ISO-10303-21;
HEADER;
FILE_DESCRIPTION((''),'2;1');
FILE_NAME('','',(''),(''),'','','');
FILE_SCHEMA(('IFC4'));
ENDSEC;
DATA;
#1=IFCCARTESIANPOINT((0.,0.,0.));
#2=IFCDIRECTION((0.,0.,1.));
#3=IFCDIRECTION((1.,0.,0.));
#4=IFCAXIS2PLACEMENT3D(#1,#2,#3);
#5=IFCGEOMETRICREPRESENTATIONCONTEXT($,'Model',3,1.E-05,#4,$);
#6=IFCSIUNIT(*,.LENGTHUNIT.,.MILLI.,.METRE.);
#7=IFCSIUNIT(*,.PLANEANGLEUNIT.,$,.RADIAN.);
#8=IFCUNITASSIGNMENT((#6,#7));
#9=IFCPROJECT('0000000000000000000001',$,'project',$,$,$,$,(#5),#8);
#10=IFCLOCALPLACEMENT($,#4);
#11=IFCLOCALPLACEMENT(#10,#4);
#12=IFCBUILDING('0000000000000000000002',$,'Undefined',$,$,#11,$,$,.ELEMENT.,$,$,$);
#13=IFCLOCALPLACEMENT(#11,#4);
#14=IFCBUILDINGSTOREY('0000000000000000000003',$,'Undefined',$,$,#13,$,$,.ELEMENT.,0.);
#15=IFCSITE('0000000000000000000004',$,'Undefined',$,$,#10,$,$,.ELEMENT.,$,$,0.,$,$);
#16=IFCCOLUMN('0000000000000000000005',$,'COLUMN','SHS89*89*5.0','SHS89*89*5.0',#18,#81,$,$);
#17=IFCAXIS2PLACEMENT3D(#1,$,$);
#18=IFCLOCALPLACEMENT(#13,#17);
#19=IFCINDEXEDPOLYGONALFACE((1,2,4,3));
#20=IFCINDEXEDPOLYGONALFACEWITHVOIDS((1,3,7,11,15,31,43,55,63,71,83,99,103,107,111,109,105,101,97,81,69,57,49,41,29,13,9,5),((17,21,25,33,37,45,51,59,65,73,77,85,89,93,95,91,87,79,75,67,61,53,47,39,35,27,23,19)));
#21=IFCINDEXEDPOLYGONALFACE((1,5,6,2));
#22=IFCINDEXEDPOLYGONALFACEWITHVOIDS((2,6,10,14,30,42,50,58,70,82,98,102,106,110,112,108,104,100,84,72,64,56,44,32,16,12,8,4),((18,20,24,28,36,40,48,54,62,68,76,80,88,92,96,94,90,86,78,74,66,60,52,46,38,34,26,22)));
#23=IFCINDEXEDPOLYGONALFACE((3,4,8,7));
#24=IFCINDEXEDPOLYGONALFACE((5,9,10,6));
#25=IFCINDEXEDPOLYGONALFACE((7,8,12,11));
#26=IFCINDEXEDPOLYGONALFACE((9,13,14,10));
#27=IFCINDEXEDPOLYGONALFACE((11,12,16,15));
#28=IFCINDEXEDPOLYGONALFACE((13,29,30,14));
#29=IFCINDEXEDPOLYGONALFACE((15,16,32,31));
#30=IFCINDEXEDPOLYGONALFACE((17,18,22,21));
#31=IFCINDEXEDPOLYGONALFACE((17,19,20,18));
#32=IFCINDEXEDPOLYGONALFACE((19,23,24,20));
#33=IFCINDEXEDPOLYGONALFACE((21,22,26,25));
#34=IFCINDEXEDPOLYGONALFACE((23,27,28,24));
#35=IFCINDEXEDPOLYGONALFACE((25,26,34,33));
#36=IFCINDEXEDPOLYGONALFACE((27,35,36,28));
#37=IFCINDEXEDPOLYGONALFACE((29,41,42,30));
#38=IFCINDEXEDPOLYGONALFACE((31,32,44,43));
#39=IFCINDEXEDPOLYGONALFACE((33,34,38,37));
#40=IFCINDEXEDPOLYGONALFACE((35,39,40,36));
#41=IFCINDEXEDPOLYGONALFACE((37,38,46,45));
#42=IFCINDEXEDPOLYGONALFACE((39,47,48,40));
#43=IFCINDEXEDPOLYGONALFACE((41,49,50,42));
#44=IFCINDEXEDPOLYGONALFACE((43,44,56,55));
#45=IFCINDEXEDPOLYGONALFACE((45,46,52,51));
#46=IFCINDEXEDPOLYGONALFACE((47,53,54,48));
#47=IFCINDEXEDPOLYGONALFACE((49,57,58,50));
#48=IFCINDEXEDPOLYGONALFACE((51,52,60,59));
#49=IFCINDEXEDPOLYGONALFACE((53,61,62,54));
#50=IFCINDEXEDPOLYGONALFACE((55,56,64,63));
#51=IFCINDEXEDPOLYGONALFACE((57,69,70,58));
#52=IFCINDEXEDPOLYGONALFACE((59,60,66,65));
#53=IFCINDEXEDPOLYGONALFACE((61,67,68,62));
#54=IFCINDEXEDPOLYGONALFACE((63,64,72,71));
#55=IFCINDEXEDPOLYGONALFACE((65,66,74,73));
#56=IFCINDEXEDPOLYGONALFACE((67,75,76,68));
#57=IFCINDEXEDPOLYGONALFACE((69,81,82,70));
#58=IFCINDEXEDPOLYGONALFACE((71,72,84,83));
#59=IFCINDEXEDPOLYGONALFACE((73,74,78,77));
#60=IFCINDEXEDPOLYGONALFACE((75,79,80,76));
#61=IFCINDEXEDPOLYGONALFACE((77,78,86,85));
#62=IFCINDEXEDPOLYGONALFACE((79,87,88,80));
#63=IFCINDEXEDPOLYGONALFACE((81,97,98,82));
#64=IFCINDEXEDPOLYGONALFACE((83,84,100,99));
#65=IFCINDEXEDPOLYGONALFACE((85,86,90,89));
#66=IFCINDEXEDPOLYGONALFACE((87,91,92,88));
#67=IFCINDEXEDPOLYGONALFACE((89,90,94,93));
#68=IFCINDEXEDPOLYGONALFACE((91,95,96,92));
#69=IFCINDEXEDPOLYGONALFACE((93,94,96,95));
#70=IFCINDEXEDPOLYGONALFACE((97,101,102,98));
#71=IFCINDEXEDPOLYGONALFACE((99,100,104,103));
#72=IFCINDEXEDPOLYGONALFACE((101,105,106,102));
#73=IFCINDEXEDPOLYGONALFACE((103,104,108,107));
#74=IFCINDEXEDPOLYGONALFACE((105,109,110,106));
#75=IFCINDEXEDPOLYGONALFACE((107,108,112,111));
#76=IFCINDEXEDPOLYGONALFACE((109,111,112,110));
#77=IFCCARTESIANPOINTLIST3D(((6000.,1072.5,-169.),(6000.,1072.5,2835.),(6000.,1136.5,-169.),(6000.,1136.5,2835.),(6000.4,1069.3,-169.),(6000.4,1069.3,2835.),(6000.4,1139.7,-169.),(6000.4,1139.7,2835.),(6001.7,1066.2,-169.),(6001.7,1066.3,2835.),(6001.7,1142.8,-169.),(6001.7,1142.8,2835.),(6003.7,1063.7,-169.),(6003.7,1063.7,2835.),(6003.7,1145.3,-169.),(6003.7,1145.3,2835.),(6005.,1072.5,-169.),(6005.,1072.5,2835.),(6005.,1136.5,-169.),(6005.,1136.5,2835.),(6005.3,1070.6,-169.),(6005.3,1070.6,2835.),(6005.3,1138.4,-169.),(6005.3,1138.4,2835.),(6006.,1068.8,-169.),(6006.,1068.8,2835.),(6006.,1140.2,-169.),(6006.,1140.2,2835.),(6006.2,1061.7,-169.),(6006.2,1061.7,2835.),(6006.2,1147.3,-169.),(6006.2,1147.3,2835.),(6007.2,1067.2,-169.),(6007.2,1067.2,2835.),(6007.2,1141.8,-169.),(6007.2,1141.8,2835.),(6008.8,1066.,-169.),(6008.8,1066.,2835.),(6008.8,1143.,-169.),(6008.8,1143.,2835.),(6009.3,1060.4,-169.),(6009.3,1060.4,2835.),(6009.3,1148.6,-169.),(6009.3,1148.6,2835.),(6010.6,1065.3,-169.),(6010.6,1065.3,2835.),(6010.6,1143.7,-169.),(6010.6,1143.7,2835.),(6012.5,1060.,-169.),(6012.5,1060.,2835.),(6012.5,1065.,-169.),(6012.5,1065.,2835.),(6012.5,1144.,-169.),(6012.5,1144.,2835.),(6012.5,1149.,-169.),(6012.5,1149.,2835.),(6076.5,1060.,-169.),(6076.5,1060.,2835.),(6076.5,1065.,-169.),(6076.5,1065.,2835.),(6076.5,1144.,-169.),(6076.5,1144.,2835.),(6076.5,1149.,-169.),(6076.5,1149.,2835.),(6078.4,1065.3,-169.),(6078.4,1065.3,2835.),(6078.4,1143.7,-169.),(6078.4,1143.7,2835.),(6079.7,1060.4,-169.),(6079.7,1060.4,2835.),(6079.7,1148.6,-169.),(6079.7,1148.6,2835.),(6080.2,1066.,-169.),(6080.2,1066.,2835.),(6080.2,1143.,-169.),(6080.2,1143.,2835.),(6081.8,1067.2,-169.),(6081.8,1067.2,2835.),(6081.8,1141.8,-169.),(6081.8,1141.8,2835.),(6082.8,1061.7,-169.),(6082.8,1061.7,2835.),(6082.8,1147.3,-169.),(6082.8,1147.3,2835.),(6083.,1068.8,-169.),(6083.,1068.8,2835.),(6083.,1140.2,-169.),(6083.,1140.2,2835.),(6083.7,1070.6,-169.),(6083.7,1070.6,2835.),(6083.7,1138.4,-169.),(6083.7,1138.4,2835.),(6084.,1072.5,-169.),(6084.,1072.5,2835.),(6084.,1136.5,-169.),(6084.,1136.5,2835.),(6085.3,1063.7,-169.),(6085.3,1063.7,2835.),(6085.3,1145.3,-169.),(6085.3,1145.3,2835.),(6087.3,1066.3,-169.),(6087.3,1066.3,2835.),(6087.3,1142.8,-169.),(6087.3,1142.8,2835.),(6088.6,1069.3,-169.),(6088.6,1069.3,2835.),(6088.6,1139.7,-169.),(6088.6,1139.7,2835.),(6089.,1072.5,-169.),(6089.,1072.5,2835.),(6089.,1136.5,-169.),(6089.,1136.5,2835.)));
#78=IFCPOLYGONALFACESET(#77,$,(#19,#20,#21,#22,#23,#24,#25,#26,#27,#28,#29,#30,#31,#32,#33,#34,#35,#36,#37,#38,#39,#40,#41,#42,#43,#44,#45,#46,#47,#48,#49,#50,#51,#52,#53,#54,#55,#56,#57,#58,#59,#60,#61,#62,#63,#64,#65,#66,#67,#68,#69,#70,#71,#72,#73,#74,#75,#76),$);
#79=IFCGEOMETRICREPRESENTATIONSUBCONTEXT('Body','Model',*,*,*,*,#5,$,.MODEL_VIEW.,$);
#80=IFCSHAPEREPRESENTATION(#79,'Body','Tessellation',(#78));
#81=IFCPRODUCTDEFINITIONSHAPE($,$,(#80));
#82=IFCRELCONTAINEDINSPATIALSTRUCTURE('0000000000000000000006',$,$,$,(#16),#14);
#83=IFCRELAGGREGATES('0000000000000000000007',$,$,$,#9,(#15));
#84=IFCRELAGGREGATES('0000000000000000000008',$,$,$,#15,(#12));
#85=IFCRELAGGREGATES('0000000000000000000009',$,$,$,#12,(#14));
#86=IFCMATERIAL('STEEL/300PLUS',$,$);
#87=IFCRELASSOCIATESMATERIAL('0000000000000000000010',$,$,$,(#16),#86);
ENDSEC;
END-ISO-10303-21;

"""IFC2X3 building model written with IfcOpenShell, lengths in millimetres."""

from ifc_helpers import new_model, si_unit, frame, origin_with_axes, origin_2d_with_axis, place, context, subcontext, project, spatial, hollow_rectangle, extrude, clip, halfspace, material, element, save


model = new_model("IFC2X3")

# Units and contexts
model_context = context("Model", 3, precision=1e-05, world=origin_with_axes())
body_context = subcontext(model_context, "Body", "Model", "MODEL_VIEW")
ifc_project = project(units=[si_unit("LENGTHUNIT", "METRE", prefix="MILLI"), si_unit("PLANEANGLEUNIT", "RADIAN")], contexts=[model_context])

# Site, building, storey
site_placement = place(None, origin_with_axes())
site = spatial("IfcSite", under=ifc_project, at=site_placement, Name="Undefined", CompositionType="ELEMENT", RefElevation=0.0)
building_placement = place(site_placement, origin_with_axes())
building = spatial("IfcBuilding", under=site, at=building_placement, Name="Undefined", CompositionType="ELEMENT")
storey_placement = place(building_placement, origin_with_axes())
storey = spatial("IfcBuildingStorey", under=building, at=storey_placement, Name="Undefined", CompositionType="ELEMENT", Elevation=0.0)

# Column
ifc_material_1 = material(Name="STEEL/300PLUS")
column_1_placement = place(storey_placement, frame((6044.5, 1104.5, -169.0), z_axis=(0.0, 0.0, 1.0), x_axis=(1.0, 0.0, 0.0)))
element("IfcColumn", 1, at=column_1_placement, inside=storey, material=ifc_material_1, Name="COLUMN", Description="SHS89*89*5.0", ObjectType="SHS89*89*5.0", context=body_context, shape_type="Clipping", body=[
    clip(extrude(hollow_rectangle(XDim=89.0, YDim=89.0, WallThickness=5.0, InnerFilletRadius=7.5, OuterFilletRadius=12.5, at=origin_2d_with_axis()), frame((0.0, 0.0, 3014.0), z_axis=(0.0, 0.0, -1.0), x_axis=(-1.0, 0.0, 0.0)), (0.0, 0.0, 1.0), 3014.0), halfspace(frame((44.5, 44.5, 3004.0), z_axis=(0.0, 0.0, 1.0), x_axis=(0.0, -1.0, 0.0)), False)),
])

save(model, "model.ifc")
